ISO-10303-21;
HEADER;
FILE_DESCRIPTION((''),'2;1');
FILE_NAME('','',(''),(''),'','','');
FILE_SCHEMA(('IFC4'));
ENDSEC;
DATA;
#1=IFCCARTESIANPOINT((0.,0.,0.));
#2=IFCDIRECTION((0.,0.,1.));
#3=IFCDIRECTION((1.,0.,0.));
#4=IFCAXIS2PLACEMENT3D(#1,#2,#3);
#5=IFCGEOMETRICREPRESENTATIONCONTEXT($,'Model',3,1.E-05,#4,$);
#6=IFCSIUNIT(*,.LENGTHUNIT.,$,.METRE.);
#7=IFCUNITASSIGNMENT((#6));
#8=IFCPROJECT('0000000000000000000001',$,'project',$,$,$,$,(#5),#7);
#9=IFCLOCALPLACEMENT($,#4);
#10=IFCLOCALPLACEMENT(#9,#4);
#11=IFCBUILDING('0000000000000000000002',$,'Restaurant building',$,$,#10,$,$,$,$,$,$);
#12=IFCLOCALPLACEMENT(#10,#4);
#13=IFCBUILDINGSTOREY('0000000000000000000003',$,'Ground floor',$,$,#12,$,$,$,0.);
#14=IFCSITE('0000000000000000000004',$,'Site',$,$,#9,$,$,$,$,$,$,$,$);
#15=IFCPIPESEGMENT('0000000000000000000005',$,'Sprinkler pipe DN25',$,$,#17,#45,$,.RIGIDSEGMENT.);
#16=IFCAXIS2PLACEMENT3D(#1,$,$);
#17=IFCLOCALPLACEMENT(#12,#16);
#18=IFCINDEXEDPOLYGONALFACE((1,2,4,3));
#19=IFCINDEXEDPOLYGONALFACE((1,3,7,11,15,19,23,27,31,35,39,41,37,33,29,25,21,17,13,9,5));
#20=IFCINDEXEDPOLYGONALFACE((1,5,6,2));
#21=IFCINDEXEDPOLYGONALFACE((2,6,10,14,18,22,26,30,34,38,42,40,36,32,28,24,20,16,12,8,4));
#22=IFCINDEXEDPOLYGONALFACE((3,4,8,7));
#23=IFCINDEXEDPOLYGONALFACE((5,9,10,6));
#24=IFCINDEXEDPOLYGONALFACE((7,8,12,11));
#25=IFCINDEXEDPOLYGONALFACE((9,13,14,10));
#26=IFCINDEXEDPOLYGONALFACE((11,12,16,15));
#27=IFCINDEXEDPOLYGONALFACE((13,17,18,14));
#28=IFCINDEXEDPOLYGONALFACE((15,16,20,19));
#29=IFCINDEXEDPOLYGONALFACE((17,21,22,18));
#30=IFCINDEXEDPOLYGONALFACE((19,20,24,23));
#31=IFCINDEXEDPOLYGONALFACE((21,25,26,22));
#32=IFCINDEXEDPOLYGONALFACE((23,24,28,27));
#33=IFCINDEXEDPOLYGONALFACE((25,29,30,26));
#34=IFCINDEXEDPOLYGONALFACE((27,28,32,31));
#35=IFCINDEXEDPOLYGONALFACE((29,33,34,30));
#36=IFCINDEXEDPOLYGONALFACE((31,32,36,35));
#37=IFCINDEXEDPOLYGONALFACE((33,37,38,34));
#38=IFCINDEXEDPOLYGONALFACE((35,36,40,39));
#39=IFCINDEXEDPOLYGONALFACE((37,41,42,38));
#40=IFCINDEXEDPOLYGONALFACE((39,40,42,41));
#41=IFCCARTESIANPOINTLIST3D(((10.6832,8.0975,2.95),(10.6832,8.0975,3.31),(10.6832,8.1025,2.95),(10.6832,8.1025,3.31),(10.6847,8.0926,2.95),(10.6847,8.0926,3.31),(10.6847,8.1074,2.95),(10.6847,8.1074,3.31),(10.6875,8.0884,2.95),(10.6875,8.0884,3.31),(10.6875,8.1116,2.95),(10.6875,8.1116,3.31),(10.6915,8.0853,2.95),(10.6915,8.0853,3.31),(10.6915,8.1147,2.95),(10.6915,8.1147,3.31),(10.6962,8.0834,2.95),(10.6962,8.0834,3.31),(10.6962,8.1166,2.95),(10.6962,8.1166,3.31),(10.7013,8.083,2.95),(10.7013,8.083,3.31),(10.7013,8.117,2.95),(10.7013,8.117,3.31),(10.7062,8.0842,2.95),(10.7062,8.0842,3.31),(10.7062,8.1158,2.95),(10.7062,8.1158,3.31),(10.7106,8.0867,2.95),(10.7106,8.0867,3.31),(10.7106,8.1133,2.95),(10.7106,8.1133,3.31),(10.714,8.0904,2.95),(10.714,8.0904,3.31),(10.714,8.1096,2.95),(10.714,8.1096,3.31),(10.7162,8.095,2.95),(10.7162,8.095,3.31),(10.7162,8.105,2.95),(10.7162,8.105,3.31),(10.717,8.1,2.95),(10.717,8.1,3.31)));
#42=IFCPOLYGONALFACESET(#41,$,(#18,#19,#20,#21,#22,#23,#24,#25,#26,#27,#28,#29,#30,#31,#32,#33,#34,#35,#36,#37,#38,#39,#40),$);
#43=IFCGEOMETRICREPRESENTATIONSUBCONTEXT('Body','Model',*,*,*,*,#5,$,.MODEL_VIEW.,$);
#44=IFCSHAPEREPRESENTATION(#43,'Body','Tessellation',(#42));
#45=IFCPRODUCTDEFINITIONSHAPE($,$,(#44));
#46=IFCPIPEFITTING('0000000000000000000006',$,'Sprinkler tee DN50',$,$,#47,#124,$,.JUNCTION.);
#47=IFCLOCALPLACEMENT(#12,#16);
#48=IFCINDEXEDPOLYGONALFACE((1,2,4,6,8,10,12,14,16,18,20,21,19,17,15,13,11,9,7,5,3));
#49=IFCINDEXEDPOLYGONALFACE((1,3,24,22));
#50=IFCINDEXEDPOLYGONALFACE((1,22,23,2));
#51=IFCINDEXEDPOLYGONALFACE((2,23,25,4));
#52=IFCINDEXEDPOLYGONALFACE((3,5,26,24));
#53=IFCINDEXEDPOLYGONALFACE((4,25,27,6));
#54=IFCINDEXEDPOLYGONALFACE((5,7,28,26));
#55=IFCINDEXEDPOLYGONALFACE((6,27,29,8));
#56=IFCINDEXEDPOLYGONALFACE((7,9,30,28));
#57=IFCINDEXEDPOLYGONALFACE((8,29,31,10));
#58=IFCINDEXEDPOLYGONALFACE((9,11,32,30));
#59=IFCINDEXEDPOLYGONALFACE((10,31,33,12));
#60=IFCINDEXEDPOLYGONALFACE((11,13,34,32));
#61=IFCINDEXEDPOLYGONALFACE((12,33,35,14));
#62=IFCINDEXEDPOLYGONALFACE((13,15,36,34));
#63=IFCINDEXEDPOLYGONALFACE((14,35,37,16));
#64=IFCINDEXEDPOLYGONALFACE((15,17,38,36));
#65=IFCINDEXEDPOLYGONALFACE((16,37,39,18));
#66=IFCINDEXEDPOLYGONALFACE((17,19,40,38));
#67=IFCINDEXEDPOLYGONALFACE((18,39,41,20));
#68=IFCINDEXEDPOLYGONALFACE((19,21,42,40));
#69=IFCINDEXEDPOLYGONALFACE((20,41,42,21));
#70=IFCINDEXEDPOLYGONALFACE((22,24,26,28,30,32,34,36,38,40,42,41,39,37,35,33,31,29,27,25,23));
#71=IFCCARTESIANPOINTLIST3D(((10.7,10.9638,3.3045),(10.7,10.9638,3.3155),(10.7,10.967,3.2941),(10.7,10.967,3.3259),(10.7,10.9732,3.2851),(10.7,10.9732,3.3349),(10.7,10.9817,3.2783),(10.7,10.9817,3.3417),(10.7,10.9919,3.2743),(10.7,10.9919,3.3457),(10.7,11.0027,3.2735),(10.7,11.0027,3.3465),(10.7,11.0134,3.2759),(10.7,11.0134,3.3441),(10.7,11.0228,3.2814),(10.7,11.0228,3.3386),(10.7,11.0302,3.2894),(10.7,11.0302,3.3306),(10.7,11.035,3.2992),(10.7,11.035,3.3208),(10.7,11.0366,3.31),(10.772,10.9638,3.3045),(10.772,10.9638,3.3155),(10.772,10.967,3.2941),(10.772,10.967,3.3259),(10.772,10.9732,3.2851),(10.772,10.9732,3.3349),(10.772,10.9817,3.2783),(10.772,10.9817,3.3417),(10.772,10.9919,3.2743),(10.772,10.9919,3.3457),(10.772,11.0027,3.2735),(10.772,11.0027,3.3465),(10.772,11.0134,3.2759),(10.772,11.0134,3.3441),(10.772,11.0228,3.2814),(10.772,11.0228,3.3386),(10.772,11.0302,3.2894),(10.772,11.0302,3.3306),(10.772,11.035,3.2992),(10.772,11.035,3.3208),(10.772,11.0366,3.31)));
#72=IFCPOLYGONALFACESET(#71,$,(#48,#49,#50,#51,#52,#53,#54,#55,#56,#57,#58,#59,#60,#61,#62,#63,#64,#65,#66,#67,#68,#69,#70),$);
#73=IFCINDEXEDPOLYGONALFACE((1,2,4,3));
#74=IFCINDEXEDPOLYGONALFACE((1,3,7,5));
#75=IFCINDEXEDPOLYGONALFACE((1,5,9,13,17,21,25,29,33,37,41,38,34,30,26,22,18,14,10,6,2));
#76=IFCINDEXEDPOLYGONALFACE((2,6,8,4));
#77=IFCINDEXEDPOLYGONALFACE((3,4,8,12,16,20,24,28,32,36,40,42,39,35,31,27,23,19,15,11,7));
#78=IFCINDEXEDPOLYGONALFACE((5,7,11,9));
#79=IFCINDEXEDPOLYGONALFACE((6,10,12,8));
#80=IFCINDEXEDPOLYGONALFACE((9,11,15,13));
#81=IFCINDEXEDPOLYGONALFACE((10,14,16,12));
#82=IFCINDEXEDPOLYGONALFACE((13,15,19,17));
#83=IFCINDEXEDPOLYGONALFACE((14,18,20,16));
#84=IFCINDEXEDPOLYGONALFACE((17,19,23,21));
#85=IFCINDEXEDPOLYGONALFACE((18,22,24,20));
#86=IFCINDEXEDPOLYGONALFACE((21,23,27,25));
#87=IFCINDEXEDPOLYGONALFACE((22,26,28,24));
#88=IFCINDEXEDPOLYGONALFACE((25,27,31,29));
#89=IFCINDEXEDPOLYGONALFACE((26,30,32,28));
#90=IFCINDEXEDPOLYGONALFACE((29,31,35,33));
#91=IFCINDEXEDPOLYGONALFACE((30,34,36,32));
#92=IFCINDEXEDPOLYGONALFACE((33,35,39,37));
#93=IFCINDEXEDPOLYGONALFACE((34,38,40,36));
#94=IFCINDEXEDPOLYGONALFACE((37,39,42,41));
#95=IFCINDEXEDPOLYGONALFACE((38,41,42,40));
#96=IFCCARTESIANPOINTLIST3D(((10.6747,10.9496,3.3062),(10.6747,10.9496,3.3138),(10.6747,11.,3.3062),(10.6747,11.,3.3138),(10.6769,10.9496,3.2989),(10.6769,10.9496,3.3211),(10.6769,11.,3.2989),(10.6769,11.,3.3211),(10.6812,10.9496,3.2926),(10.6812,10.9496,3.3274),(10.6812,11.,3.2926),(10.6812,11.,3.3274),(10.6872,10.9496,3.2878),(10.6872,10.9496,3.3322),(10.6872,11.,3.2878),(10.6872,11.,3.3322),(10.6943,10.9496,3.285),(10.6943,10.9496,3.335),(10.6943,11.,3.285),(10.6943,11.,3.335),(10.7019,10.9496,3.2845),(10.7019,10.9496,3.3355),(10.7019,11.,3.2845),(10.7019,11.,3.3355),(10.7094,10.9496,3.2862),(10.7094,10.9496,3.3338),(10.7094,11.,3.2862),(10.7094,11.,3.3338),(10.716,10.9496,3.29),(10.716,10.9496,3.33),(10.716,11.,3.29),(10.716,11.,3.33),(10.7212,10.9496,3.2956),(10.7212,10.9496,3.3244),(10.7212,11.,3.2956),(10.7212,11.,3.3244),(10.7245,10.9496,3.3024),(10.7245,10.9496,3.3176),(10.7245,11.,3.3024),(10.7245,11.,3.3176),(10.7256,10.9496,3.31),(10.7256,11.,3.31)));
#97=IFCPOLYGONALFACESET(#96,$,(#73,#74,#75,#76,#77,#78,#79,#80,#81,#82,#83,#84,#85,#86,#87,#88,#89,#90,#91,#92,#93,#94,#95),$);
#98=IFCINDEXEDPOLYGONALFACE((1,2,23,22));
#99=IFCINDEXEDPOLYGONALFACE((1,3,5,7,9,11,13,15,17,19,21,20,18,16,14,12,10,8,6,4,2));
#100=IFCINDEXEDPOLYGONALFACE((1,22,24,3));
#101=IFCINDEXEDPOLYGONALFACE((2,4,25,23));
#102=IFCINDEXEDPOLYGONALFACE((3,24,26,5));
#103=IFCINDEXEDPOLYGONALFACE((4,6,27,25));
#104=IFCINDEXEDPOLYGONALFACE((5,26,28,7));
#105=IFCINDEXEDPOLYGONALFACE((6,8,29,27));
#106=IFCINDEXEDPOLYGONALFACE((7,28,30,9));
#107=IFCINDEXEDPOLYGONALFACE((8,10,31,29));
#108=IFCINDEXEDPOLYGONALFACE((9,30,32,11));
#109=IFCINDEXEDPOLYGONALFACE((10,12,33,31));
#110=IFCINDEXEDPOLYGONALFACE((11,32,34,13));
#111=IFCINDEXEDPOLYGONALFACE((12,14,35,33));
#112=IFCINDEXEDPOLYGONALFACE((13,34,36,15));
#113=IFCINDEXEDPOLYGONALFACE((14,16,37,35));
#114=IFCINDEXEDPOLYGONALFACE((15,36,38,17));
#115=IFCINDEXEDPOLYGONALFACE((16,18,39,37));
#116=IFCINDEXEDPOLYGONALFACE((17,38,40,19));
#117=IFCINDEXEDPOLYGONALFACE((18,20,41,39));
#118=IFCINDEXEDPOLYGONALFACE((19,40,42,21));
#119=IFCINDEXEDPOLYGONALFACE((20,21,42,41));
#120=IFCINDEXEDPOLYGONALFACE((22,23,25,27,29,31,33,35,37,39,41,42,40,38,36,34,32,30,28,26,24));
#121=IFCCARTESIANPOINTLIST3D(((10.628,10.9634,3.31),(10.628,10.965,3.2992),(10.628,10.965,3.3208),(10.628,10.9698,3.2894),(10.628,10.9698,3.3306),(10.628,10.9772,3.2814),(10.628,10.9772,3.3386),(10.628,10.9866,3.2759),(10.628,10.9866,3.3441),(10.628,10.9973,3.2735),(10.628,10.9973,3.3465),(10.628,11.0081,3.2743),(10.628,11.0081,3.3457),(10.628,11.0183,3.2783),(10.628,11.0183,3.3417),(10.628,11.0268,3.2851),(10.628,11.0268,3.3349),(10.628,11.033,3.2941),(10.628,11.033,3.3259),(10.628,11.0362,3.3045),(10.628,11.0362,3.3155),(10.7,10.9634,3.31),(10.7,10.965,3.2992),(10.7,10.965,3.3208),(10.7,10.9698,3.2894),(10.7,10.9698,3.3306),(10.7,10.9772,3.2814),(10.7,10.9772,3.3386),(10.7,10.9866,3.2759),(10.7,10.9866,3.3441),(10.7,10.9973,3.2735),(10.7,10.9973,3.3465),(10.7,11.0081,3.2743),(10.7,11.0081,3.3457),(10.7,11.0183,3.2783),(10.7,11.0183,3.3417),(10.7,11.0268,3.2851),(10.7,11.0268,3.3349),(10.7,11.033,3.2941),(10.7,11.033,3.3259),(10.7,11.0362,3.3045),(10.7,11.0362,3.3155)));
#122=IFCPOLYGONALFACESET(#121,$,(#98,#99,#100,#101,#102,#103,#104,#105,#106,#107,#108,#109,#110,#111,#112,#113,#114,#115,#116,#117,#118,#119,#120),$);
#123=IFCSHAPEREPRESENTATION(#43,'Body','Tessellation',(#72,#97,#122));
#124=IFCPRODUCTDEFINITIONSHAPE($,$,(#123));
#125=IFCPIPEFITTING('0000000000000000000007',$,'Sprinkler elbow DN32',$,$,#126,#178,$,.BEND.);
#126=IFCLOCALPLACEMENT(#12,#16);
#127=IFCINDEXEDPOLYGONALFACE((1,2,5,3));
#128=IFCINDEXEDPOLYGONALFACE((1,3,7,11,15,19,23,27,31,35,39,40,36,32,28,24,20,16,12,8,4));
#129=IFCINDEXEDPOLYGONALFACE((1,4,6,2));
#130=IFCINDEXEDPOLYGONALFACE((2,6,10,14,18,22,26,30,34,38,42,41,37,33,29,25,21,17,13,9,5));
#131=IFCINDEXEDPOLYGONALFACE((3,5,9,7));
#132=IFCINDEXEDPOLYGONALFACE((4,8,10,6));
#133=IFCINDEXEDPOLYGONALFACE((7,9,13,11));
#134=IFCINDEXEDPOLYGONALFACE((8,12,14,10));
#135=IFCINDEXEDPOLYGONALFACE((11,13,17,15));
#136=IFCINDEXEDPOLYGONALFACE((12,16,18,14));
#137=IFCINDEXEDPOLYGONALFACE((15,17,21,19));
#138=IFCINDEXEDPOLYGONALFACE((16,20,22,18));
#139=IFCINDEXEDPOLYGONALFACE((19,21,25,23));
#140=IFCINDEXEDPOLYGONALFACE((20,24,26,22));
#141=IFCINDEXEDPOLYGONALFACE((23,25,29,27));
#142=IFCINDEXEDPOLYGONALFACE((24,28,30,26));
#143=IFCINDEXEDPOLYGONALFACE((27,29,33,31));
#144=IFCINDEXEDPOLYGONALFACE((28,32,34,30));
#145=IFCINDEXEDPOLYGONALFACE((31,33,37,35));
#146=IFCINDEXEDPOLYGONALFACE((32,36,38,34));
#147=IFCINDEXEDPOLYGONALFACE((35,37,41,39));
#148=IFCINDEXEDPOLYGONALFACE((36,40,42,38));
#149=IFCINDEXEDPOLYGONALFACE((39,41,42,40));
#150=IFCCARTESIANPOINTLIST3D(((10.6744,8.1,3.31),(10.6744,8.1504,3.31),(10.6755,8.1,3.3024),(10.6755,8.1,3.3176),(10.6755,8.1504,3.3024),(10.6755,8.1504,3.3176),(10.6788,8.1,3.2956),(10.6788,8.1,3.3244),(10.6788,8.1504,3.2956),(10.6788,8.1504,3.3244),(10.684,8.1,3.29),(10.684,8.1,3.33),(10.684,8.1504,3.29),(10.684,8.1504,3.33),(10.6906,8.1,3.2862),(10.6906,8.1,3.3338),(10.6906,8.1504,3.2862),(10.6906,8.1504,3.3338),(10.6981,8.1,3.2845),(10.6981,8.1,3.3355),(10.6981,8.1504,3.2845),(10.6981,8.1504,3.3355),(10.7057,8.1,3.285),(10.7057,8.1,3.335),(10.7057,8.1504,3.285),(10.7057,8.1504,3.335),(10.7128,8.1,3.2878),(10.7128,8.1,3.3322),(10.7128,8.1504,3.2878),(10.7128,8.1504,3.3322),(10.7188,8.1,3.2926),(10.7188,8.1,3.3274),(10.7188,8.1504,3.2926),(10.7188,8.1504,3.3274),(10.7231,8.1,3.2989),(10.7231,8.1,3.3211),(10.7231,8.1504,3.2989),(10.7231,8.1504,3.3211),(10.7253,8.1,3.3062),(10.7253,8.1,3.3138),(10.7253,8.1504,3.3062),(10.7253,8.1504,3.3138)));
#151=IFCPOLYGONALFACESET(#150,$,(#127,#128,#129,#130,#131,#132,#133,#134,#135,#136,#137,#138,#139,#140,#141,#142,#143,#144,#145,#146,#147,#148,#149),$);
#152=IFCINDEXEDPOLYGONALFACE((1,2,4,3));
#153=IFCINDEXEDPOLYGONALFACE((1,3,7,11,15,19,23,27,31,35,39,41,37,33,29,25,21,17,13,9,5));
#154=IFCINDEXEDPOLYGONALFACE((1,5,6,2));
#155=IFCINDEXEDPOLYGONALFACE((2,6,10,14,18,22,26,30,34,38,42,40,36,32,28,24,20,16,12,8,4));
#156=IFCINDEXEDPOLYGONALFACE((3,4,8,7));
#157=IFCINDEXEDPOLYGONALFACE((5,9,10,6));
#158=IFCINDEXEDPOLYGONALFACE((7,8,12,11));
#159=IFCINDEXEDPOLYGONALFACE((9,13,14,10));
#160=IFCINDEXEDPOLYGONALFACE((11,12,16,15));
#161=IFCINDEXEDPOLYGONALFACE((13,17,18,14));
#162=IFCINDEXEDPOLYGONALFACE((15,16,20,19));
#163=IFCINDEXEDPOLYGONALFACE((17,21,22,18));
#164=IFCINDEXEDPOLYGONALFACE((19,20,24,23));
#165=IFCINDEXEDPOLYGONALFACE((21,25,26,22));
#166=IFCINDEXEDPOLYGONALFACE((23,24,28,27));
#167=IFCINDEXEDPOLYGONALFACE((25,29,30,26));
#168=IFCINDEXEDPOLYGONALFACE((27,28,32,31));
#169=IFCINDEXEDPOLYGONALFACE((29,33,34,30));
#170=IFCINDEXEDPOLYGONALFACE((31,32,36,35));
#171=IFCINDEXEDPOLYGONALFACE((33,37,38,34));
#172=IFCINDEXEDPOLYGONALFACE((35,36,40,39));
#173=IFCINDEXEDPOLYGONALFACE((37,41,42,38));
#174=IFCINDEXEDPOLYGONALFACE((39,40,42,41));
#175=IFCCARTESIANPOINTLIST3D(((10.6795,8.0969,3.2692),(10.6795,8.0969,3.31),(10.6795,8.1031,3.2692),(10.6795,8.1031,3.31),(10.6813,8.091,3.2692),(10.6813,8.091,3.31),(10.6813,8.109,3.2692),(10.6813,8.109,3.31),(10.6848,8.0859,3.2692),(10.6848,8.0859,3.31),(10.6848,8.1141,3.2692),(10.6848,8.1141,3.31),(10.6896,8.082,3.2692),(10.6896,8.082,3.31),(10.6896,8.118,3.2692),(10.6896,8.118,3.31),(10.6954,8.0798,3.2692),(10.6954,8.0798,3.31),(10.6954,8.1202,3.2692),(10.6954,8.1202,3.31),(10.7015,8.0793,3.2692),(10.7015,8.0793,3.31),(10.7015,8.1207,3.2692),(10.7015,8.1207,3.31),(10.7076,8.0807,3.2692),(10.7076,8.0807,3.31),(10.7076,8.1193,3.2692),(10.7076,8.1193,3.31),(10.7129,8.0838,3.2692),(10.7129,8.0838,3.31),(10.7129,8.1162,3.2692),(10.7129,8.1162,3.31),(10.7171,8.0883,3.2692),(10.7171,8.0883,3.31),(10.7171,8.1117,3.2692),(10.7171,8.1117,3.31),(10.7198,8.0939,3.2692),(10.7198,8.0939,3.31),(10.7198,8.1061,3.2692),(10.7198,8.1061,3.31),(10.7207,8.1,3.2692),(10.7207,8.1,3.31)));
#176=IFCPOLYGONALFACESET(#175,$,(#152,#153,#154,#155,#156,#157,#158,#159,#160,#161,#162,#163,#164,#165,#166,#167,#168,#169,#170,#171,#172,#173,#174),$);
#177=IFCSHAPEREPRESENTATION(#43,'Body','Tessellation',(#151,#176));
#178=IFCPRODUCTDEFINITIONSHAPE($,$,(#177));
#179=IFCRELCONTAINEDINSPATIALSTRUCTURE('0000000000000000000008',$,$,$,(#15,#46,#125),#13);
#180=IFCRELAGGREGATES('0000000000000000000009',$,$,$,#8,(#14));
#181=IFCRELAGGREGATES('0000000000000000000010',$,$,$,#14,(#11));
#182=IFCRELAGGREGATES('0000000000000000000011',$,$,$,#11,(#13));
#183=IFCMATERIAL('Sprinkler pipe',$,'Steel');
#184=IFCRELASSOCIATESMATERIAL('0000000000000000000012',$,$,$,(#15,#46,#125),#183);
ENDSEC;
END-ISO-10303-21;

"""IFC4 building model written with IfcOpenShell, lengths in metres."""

from ifc_helpers import new_model, si_unit, frame, origin_with_axes, origin_2d, place, context, subcontext, project, spatial, circle, extrude, material, element, save


model = new_model("IFC4")

# Units and contexts
model_context = context("Model", 3, precision=1e-05, world=origin_with_axes())
body_context = subcontext(model_context, "Body", "Model", "MODEL_VIEW")
ifc_project = project(units=[si_unit("LENGTHUNIT", "METRE")], contexts=[model_context])

# Site, building, storey
site_placement = place(None, origin_with_axes())
site = spatial("IfcSite", under=ifc_project, at=site_placement, Name="Site")
building_placement = place(site_placement, origin_with_axes())
building = spatial("IfcBuilding", under=site, at=building_placement, Name="Restaurant building")
storey_placement = place(building_placement, origin_with_axes())
storey = spatial("IfcBuildingStorey", under=building, at=storey_placement, Name="Ground floor", Elevation=0.0)

# Pipe segment
ifc_material_1 = material(Name="Sprinkler pipe", Category="Steel")
for number, where, name in (
    (1, (10.7, 8.1, 3.31), "Sprinkler pipe DN25"),
):
    element("IfcPipeSegment", number, at=place(storey_placement, frame(where)), inside=storey, material=ifc_material_1, Name=name, PredefinedType="RIGIDSEGMENT", context=body_context, shape_type="SweptSolid", body=[
        extrude(circle(Radius=0.017, at=origin_2d()), frame((0.0, 0.0, 0.0), z_axis=(0.0, 0.0, -1.0), x_axis=(1.0, 0.0, 0.0)), (0.0, 0.0, 1.0), 0.36),
    ])

# Pipe fittings
pipe_fitting_1_placement = place(storey_placement, frame((10.7, 11.0, 3.31)))
element("IfcPipeFitting", 2, at=pipe_fitting_1_placement, inside=storey, material=ifc_material_1, Name="Sprinkler tee DN50", PredefinedType="JUNCTION", context=body_context, shape_type="SweptSolid", body=[
    extrude(circle(Radius=0.0366, at=origin_2d()), frame((0.0, 0.0, 0.0), z_axis=(1.0, 0.0, 0.0), x_axis=(0.0, 1.0, 0.0)), (0.0, 0.0, 1.0), 0.072),
    extrude(circle(Radius=0.0256, at=origin_2d()), frame((0.0, 0.0, 0.0), z_axis=(0.0, -1.0, 0.0), x_axis=(1.0, 0.0, 0.0)), (0.0, 0.0, 1.0), 0.0504),
    extrude(circle(Radius=0.0366, at=origin_2d()), frame((0.0, 0.0, 0.0), z_axis=(-1.0, 0.0, 0.0), x_axis=(0.0, -1.0, 0.0)), (0.0, 0.0, 1.0), 0.072),
])
pipe_fitting_2_placement = place(storey_placement, frame((10.7, 8.1, 3.31)))
element("IfcPipeFitting", 3, at=pipe_fitting_2_placement, inside=storey, material=ifc_material_1, Name="Sprinkler elbow DN32", PredefinedType="BEND", context=body_context, shape_type="SweptSolid", body=[
    extrude(circle(Radius=0.0256, at=origin_2d()), frame((0.0, 0.0, 0.0), z_axis=(0.0, 1.0, 0.0), x_axis=(-1.0, 0.0, 0.0)), (0.0, 0.0, 1.0), 0.0504),
    extrude(circle(Radius=0.0207, at=origin_2d()), frame((0.0, 0.0, 0.0), z_axis=(0.0, 0.0, -1.0), x_axis=(1.0, 0.0, 0.0)), (0.0, 0.0, 1.0), 0.0408),
])

save(model, "model.ifc")
